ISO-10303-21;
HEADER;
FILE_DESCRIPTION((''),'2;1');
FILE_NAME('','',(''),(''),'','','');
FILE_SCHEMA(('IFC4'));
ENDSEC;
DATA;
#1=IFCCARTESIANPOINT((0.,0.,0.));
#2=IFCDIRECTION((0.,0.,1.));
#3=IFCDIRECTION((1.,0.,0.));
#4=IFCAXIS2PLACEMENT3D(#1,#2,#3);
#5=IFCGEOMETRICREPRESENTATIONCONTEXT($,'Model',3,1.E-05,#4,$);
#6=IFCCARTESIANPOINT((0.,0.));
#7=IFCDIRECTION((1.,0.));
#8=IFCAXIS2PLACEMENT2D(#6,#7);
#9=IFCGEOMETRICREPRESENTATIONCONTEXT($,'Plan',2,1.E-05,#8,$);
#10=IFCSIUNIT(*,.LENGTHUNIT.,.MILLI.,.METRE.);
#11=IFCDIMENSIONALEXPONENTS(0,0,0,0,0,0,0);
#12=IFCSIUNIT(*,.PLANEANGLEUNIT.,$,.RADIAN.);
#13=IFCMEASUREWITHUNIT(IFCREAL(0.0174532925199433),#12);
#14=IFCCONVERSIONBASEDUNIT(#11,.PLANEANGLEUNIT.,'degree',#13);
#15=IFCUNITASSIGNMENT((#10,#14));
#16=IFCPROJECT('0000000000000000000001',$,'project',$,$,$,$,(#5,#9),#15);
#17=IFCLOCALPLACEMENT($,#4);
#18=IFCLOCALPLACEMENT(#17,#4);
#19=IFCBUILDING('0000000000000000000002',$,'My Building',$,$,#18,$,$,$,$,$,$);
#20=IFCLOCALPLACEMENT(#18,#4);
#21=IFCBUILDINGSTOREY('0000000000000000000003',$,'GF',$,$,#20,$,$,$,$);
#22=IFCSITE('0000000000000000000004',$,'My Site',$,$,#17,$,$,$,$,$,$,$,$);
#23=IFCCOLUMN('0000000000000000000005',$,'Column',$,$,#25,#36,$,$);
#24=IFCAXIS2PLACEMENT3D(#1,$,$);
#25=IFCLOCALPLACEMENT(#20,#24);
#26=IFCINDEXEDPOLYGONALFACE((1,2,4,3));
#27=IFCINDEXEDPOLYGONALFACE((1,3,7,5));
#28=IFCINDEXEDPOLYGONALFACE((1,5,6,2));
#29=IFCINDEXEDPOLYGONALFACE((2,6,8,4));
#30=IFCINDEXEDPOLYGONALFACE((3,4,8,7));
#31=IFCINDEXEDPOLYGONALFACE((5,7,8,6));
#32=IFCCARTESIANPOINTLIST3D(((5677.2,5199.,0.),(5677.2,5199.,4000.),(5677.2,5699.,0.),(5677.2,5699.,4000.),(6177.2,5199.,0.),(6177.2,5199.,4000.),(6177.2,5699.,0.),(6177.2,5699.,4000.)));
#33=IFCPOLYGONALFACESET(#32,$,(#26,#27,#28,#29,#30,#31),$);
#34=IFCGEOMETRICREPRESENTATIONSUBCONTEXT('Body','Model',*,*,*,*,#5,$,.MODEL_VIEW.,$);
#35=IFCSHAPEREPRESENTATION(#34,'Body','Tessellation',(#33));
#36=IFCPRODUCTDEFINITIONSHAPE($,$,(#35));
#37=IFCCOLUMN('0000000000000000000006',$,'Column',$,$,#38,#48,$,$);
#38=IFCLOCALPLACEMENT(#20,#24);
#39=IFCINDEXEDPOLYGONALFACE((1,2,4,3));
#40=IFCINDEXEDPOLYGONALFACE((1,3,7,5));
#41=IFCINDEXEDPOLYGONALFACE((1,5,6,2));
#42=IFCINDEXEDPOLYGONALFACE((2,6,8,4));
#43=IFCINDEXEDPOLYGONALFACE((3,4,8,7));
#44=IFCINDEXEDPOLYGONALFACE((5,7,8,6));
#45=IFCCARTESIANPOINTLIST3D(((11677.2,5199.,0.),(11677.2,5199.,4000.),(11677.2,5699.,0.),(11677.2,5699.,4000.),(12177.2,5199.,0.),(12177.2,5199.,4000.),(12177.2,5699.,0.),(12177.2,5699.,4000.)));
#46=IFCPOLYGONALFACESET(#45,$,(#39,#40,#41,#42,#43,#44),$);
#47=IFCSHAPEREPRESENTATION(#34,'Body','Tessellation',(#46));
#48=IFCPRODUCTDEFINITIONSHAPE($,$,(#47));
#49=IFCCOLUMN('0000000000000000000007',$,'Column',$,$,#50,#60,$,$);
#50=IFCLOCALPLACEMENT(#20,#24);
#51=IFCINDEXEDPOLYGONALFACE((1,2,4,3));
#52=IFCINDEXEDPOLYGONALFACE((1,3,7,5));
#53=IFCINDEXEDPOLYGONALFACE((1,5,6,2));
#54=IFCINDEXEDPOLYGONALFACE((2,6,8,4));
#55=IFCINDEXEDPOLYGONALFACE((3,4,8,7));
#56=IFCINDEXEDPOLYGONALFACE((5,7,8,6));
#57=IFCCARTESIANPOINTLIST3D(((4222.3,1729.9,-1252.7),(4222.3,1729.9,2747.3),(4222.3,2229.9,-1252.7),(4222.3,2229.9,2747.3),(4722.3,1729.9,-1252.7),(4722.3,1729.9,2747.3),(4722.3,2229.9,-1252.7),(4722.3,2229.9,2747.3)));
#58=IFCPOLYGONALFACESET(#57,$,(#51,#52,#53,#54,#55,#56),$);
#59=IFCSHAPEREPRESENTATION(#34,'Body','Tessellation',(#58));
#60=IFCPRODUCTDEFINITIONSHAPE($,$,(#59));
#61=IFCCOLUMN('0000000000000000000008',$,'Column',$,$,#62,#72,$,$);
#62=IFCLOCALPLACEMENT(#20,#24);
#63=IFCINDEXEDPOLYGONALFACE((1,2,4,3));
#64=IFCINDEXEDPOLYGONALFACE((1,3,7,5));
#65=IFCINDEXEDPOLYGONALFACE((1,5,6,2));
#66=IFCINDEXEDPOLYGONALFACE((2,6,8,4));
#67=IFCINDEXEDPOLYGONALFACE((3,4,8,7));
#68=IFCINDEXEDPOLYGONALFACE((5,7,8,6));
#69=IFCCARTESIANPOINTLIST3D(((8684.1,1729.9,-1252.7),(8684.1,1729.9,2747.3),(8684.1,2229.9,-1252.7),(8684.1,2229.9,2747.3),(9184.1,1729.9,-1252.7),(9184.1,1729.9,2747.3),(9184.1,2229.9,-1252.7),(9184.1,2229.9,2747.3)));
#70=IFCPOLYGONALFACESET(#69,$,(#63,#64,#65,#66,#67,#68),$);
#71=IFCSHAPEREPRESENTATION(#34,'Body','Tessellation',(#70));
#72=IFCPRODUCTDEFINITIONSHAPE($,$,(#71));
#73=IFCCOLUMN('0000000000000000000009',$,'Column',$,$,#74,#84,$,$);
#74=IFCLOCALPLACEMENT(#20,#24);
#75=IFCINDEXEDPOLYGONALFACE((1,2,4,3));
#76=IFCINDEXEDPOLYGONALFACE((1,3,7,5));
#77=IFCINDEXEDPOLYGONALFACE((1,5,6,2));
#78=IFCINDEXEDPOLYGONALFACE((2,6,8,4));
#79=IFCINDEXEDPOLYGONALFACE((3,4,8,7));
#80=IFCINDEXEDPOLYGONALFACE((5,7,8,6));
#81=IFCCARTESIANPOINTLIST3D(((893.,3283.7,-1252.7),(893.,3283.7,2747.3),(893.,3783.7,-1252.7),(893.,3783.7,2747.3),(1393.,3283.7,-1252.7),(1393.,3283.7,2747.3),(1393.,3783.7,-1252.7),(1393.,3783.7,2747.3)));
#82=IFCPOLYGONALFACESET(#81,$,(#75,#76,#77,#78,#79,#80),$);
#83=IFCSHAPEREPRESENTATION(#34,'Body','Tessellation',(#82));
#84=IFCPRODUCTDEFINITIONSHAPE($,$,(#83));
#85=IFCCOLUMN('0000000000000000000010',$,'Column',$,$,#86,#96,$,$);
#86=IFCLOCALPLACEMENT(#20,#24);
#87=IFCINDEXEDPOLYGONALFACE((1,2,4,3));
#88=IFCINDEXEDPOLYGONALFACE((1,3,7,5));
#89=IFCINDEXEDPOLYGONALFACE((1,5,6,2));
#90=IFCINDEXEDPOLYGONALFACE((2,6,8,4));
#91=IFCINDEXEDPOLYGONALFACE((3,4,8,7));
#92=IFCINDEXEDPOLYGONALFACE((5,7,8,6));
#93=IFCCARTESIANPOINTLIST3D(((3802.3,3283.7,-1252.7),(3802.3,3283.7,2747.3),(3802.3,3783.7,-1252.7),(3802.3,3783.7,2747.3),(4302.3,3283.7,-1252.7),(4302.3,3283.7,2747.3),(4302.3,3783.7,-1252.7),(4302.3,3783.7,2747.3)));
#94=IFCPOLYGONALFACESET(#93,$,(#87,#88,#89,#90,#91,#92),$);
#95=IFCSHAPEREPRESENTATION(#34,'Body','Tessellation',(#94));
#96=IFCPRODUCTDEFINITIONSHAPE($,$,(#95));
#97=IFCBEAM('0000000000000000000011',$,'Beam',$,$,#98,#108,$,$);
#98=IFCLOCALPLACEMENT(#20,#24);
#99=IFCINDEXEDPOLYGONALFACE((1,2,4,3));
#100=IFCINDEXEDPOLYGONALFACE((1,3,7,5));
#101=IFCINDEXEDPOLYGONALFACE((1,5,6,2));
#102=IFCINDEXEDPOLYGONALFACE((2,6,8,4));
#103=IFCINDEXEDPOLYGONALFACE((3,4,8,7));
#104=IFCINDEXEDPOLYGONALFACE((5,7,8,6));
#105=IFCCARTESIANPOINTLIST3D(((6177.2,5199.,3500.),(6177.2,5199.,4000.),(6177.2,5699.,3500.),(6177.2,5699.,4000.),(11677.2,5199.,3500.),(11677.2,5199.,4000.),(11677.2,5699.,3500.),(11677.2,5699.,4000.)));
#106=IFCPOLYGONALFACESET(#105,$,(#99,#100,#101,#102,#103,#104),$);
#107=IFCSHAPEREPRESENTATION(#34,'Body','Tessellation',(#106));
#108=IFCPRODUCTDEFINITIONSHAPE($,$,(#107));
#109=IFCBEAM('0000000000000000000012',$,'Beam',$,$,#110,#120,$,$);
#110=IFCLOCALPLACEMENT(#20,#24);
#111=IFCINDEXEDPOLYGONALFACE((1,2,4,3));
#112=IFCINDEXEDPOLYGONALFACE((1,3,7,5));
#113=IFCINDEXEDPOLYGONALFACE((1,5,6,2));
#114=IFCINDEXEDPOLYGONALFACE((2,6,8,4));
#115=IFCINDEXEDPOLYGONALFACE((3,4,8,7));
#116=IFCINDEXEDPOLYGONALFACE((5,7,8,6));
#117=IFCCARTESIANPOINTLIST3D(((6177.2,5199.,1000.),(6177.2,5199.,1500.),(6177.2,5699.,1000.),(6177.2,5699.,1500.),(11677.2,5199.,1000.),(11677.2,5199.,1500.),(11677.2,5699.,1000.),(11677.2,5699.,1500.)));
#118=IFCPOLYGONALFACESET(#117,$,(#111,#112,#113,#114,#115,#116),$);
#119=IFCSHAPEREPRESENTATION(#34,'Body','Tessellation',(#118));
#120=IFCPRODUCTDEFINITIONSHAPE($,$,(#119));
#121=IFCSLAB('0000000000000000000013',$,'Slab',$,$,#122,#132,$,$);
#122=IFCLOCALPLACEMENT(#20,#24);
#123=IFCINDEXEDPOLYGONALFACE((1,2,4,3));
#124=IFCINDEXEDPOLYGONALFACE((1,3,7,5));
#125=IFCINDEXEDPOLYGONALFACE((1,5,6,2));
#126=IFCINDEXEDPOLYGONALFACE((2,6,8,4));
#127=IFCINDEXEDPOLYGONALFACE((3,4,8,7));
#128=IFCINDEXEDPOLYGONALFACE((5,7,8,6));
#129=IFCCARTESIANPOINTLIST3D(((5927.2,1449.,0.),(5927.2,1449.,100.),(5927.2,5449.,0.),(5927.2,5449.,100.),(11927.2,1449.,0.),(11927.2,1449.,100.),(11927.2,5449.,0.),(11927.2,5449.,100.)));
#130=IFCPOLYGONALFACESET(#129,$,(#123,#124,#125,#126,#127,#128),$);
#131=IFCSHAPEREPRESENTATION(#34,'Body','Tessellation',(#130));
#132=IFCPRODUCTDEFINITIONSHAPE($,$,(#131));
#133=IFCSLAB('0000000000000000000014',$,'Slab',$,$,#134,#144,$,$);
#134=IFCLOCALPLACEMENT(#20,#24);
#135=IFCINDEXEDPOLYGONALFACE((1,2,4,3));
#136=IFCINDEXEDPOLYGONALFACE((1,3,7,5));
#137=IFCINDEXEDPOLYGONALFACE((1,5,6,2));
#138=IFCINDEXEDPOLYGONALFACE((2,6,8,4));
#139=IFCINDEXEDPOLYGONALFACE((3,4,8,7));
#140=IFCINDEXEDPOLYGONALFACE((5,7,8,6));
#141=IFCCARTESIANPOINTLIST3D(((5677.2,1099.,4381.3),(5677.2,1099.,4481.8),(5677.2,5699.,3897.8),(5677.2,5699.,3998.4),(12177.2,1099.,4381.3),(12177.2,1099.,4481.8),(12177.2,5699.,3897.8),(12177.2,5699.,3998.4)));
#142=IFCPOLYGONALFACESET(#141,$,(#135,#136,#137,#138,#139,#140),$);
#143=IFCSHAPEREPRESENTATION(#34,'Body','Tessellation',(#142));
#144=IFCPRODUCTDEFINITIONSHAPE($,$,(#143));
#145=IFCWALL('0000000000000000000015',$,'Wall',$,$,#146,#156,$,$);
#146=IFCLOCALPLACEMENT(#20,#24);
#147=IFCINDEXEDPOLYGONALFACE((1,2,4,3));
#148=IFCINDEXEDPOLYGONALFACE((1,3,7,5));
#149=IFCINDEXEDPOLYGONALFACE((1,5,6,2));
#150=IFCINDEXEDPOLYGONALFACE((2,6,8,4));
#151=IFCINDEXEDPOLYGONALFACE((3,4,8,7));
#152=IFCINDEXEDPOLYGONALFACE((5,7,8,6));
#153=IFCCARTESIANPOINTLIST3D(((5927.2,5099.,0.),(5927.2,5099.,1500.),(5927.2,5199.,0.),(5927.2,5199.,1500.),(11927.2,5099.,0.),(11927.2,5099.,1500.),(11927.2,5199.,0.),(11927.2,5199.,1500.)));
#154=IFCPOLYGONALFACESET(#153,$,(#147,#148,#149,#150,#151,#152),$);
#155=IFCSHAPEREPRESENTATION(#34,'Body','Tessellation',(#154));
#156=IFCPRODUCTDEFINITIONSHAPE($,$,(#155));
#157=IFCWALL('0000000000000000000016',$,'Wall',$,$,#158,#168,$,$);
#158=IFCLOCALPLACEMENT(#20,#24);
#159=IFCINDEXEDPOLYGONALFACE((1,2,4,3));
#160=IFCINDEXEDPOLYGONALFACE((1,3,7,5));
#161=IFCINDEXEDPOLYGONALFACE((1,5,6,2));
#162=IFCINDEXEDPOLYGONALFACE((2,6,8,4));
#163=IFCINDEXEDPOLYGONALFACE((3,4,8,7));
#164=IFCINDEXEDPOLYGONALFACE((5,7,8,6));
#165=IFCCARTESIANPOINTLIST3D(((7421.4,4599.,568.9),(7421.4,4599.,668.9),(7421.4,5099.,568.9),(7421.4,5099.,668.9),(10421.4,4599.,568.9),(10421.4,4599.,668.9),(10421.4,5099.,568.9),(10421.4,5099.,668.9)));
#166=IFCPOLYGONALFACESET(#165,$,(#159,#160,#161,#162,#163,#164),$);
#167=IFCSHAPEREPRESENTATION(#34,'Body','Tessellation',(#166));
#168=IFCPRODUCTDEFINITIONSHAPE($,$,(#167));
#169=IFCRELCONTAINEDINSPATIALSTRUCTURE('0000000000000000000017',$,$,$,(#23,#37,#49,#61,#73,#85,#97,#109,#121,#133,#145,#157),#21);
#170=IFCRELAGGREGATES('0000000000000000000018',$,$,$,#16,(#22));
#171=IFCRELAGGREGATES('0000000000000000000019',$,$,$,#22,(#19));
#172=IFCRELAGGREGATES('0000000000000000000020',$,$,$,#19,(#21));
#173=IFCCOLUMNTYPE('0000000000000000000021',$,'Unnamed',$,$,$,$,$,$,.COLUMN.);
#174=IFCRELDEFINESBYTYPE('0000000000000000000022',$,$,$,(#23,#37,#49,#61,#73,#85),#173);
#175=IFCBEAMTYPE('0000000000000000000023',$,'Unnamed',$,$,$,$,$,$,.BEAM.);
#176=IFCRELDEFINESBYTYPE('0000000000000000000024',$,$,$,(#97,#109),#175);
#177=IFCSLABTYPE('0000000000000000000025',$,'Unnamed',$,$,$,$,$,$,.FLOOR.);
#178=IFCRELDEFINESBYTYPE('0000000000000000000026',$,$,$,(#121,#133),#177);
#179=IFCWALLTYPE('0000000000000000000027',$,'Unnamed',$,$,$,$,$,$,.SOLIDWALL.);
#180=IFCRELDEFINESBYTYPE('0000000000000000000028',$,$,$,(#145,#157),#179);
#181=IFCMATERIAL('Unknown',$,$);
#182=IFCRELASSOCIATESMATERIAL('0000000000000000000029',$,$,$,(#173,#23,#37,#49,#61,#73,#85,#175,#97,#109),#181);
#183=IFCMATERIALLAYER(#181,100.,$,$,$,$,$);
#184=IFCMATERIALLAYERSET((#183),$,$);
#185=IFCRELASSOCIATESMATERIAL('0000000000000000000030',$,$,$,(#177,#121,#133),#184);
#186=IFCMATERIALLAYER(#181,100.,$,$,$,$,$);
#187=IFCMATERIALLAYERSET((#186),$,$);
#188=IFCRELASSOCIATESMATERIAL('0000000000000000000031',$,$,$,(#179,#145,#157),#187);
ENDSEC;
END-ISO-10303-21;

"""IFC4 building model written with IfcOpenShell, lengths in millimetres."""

from ifc_helpers import new_model, entity, si_unit, converted_unit, frame, origin_with_axes, origin_2d_with_axis, place, context, subcontext, project, spatial, line, indexed_curve, rectangle, outline, extrude, material, layer, layer_set, layer_usage, material_profile, profile_set, profile_usage, type_object, element, save


model = new_model("IFC4")

# Units and contexts
model_context = context("Model", 3, precision=1e-05, world=origin_with_axes())
plan_context = context("Plan", 2, precision=1e-05, world=origin_2d_with_axis())
body_context = subcontext(model_context, "Body", "Model", "MODEL_VIEW")
ifc_project = project(units=[si_unit("LENGTHUNIT", "METRE", prefix="MILLI"), converted_unit("PLANEANGLEUNIT", "degree", entity("IfcReal", 0.0174532925199433), si_unit("PLANEANGLEUNIT", "RADIAN"), dimensions=[0, 0, 0, 0, 0, 0, 0])], contexts=[model_context, plan_context])

# Site, building, storey
site_placement = place(None, origin_with_axes())
site = spatial("IfcSite", under=ifc_project, at=site_placement, Name="My Site")
building_placement = place(site_placement, origin_with_axes())
building = spatial("IfcBuilding", under=site, at=building_placement, Name="My Building")
storey_placement = place(building_placement, origin_with_axes())
storey = spatial("IfcBuildingStorey", under=building, at=storey_placement, Name="GF")

# Columns
ifc_material = material(Name="Unknown")
ifc_material_profile_1 = material_profile(ifc_material, rectangle(XDim=500.0, YDim=500.0))
ifc_profile_set_1 = profile_set([ifc_material_profile_1])
ifc_profile_usage_1 = profile_usage(ifc_profile_set_1, cardinal=10)
column_type = type_object("IfcColumnType", Name="Unnamed", PredefinedType="COLUMN", material=ifc_profile_set_1)
column_1_placement = place(storey_placement, frame((5927.2, 5449.0, 0.0), z_axis=(0.0, 0.0, 1.0), x_axis=(1.0, 0.0, 0.0)))
element("IfcColumn", 1, at=column_1_placement, inside=storey, type_object=column_type, material=ifc_profile_usage_1, Name="Column", context=body_context, shape_type="SweptSolid", body=[
    extrude(rectangle(XDim=500.0, YDim=500.0), origin_with_axes(), (0.0, 0.0, 1.0), 4000.0),
])
ifc_profile_usage_2 = profile_usage(ifc_profile_set_1, cardinal=10)
column_2_placement = place(storey_placement, frame((11927.2, 5449.0, 0.0), z_axis=(0.0, 0.0, 1.0), x_axis=(1.0, 0.0, 0.0)))
element("IfcColumn", 2, at=column_2_placement, inside=storey, type_object=column_type, material=ifc_profile_usage_2, Name="Column", context=body_context, shape_type="SweptSolid", body=[
    extrude(rectangle(XDim=500.0, YDim=500.0), origin_with_axes(), (0.0, 0.0, 1.0), 4000.0),
])
ifc_profile_usage_3 = profile_usage(ifc_profile_set_1, cardinal=5)
column_3_placement = place(storey_placement, frame((4472.3, 1979.9, -1252.7), z_axis=(0.0, 0.0, 1.0), x_axis=(1.0, 0.0, 0.0)))
element("IfcColumn", 3, at=column_3_placement, inside=storey, type_object=column_type, material=ifc_profile_usage_3, Name="Column", context=body_context, shape_type="SweptSolid", body=[
    extrude(rectangle(XDim=500.0, YDim=500.0), origin_with_axes(), (0.0, 0.0, 1.0), 4000.0),
])
ifc_profile_usage_4 = profile_usage(ifc_profile_set_1, cardinal=5)
column_4_placement = place(storey_placement, frame((8934.1, 1979.9, -1252.7), z_axis=(0.0, 0.0, 1.0), x_axis=(1.0, 0.0, 0.0)))
element("IfcColumn", 4, at=column_4_placement, inside=storey, type_object=column_type, material=ifc_profile_usage_4, Name="Column", context=body_context, shape_type="SweptSolid", body=[
    extrude(rectangle(XDim=500.0, YDim=500.0), origin_with_axes(), (0.0, 0.0, 1.0), 4000.0),
])
ifc_profile_usage_5 = profile_usage(ifc_profile_set_1, cardinal=5)
column_5_placement = place(storey_placement, frame((1143.0, 3533.7, -1252.7), z_axis=(0.0, 0.0, 1.0), x_axis=(1.0, 0.0, 0.0)))
element("IfcColumn", 5, at=column_5_placement, inside=storey, type_object=column_type, material=ifc_profile_usage_5, Name="Column", context=body_context, shape_type="SweptSolid", body=[
    extrude(rectangle(XDim=500.0, YDim=500.0), origin_with_axes(), (0.0, 0.0, 1.0), 4000.0),
])
ifc_profile_usage_6 = profile_usage(ifc_profile_set_1, cardinal=5)
column_6_placement = place(storey_placement, frame((4052.3, 3533.7, -1252.7), z_axis=(0.0, 0.0, 1.0), x_axis=(1.0, 0.0, 0.0)))
element("IfcColumn", 6, at=column_6_placement, inside=storey, type_object=column_type, material=ifc_profile_usage_6, Name="Column", context=body_context, shape_type="SweptSolid", body=[
    extrude(rectangle(XDim=500.0, YDim=500.0), origin_with_axes(), (0.0, 0.0, 1.0), 4000.0),
])

# Beams
ifc_material_profile_2 = material_profile(ifc_material, rectangle(XDim=500.0, YDim=500.0))
ifc_profile_set_2 = profile_set([ifc_material_profile_2])
ifc_profile_usage_7 = profile_usage(ifc_profile_set_2, cardinal=7)
beam_type = type_object("IfcBeamType", Name="Unnamed", PredefinedType="BEAM", material=ifc_profile_set_2)
beam_1_placement = place(storey_placement, frame((6177.2, 5699.0, 4000.0), z_axis=(1.0, 0.0, 0.0), x_axis=(0.0, 1.0, 0.0)))
element("IfcBeam", 7, at=beam_1_placement, inside=storey, type_object=beam_type, material=ifc_profile_usage_7, Name="Beam", context=body_context, shape_type="SweptSolid", body=[
    extrude(rectangle(XDim=500.0, YDim=500.0), frame((-250.0, -250.0, 0.0), z_axis=(0.0, 0.0, 1.0), x_axis=(1.0, 0.0, 0.0)), (0.0, 0.0, 1.0), 5500.0),
])
ifc_profile_usage_8 = profile_usage(ifc_profile_set_2, cardinal=7)
beam_2_placement = place(storey_placement, frame((6177.2, 5699.0, 1500.0), z_axis=(1.0, 0.0, 0.0), x_axis=(0.0, 1.0, 0.0)))
element("IfcBeam", 8, at=beam_2_placement, inside=storey, type_object=beam_type, material=ifc_profile_usage_8, Name="Beam", context=body_context, shape_type="SweptSolid", body=[
    extrude(rectangle(XDim=500.0, YDim=500.0), frame((-250.0, -250.0, 0.0), z_axis=(0.0, 0.0, 1.0), x_axis=(1.0, 0.0, 0.0)), (0.0, 0.0, 1.0), 5500.0),
])

# Slabs
ifc_layer_1 = layer(ifc_material, 100.0)
ifc_layer_set_1 = layer_set([ifc_layer_1])
ifc_layer_usage_1 = layer_usage(ifc_layer_set_1, "AXIS3", "POSITIVE", -100.0)
slab_type = type_object("IfcSlabType", Name="Unnamed", PredefinedType="FLOOR", material=ifc_layer_set_1)
slab_1_placement = place(storey_placement, frame((5927.2, 5449.0, 100.0), z_axis=(0.0, 0.0, 1.0), x_axis=(1.0, 0.0, 0.0)))
element("IfcSlab", 9, at=slab_1_placement, inside=storey, type_object=slab_type, material=ifc_layer_usage_1, Name="Slab", context=body_context, shape_type="SweptSolid", body=[
    extrude(outline(indexed_curve([(0.0, 0.0), (0.0, -4000.0), (6000.0, -4000.0), (6000.0, 0.0), (0.0, 0.0)])), frame((0.0, 0.0, -100.0), z_axis=(0.0, 0.0, 1.0), x_axis=(1.0, 0.0, 0.0)), (0.0, 0.0, 1.0), 100.0),
])
ifc_layer_usage_2 = layer_usage(ifc_layer_set_1, "AXIS3", "POSITIVE", -100.0)
slab_2_placement = place(storey_placement, frame((5677.2, 5699.0, 3998.4), z_axis=(0.0, 0.104529, 0.994522), x_axis=(1.0, 0.0, 0.0)))
element("IfcSlab", 10, at=slab_2_placement, inside=storey, type_object=slab_type, material=ifc_layer_usage_2, Name="Slab", context=body_context, shape_type="SweptSolid", body=[
    extrude(outline(indexed_curve([(0.0, 0.0), (6500.0, 0.0), (6500.0, -4625.3), (0.0, -4625.3), (0.0, 0.0)])), frame((0.0, 10.5, -100.0), z_axis=(0.0, 0.0, 1.0), x_axis=(1.0, 0.0, 0.0)), (0.0, -0.104528, 0.994522), 100.6),
])

# Walls
ifc_layer_2 = layer(ifc_material, 100.0)
ifc_layer_set_2 = layer_set([ifc_layer_2])
ifc_layer_usage_3 = layer_usage(ifc_layer_set_2, "AXIS2", "POSITIVE", 0.0)
wall_type = type_object("IfcWallType", Name="Unnamed", PredefinedType="SOLIDWALL", material=ifc_layer_set_2)
wall_1_placement = place(storey_placement, frame((11927.2, 5199.0, 0.0), z_axis=(0.0, 0.0, 1.0), x_axis=(-1.0, 0.0, 0.0)))
element("IfcWall", 11, at=wall_1_placement, inside=storey, type_object=wall_type, material=ifc_layer_usage_3, Name="Wall", context=body_context, shape_type="SweptSolid", body=[
    extrude(outline(indexed_curve([(0.0, 0.0), (0.0, 100.0), (6000.0, 100.0), (6000.0, 0.0)], segments=[line(1, 2, 3, 4, 1)])), origin_with_axes(), (0.0, 0.0, 1.0), 1500.0),
])
ifc_layer_usage_4 = layer_usage(ifc_layer_set_2, "AXIS2", "POSITIVE", 0.0)
wall_2_placement = place(storey_placement, frame((7421.4, 4599.0, 568.9), z_axis=(1.0, 0.0, -0.00001), x_axis=(0.0, 1.0, 0.0)))
element("IfcWall", 12, at=wall_2_placement, inside=storey, type_object=wall_type, material=ifc_layer_usage_4, Name="Wall", context=body_context, shape_type="SweptSolid", body=[
    extrude(outline(indexed_curve([(0.0, 0.0), (0.0, 100.0), (500.0, 100.0), (500.0, 0.0)], segments=[line(1, 2, 3, 4, 1)])), origin_with_axes(), (0.0, 0.0, 1.0), 3000.0),
])

save(model, "model.ifc")
